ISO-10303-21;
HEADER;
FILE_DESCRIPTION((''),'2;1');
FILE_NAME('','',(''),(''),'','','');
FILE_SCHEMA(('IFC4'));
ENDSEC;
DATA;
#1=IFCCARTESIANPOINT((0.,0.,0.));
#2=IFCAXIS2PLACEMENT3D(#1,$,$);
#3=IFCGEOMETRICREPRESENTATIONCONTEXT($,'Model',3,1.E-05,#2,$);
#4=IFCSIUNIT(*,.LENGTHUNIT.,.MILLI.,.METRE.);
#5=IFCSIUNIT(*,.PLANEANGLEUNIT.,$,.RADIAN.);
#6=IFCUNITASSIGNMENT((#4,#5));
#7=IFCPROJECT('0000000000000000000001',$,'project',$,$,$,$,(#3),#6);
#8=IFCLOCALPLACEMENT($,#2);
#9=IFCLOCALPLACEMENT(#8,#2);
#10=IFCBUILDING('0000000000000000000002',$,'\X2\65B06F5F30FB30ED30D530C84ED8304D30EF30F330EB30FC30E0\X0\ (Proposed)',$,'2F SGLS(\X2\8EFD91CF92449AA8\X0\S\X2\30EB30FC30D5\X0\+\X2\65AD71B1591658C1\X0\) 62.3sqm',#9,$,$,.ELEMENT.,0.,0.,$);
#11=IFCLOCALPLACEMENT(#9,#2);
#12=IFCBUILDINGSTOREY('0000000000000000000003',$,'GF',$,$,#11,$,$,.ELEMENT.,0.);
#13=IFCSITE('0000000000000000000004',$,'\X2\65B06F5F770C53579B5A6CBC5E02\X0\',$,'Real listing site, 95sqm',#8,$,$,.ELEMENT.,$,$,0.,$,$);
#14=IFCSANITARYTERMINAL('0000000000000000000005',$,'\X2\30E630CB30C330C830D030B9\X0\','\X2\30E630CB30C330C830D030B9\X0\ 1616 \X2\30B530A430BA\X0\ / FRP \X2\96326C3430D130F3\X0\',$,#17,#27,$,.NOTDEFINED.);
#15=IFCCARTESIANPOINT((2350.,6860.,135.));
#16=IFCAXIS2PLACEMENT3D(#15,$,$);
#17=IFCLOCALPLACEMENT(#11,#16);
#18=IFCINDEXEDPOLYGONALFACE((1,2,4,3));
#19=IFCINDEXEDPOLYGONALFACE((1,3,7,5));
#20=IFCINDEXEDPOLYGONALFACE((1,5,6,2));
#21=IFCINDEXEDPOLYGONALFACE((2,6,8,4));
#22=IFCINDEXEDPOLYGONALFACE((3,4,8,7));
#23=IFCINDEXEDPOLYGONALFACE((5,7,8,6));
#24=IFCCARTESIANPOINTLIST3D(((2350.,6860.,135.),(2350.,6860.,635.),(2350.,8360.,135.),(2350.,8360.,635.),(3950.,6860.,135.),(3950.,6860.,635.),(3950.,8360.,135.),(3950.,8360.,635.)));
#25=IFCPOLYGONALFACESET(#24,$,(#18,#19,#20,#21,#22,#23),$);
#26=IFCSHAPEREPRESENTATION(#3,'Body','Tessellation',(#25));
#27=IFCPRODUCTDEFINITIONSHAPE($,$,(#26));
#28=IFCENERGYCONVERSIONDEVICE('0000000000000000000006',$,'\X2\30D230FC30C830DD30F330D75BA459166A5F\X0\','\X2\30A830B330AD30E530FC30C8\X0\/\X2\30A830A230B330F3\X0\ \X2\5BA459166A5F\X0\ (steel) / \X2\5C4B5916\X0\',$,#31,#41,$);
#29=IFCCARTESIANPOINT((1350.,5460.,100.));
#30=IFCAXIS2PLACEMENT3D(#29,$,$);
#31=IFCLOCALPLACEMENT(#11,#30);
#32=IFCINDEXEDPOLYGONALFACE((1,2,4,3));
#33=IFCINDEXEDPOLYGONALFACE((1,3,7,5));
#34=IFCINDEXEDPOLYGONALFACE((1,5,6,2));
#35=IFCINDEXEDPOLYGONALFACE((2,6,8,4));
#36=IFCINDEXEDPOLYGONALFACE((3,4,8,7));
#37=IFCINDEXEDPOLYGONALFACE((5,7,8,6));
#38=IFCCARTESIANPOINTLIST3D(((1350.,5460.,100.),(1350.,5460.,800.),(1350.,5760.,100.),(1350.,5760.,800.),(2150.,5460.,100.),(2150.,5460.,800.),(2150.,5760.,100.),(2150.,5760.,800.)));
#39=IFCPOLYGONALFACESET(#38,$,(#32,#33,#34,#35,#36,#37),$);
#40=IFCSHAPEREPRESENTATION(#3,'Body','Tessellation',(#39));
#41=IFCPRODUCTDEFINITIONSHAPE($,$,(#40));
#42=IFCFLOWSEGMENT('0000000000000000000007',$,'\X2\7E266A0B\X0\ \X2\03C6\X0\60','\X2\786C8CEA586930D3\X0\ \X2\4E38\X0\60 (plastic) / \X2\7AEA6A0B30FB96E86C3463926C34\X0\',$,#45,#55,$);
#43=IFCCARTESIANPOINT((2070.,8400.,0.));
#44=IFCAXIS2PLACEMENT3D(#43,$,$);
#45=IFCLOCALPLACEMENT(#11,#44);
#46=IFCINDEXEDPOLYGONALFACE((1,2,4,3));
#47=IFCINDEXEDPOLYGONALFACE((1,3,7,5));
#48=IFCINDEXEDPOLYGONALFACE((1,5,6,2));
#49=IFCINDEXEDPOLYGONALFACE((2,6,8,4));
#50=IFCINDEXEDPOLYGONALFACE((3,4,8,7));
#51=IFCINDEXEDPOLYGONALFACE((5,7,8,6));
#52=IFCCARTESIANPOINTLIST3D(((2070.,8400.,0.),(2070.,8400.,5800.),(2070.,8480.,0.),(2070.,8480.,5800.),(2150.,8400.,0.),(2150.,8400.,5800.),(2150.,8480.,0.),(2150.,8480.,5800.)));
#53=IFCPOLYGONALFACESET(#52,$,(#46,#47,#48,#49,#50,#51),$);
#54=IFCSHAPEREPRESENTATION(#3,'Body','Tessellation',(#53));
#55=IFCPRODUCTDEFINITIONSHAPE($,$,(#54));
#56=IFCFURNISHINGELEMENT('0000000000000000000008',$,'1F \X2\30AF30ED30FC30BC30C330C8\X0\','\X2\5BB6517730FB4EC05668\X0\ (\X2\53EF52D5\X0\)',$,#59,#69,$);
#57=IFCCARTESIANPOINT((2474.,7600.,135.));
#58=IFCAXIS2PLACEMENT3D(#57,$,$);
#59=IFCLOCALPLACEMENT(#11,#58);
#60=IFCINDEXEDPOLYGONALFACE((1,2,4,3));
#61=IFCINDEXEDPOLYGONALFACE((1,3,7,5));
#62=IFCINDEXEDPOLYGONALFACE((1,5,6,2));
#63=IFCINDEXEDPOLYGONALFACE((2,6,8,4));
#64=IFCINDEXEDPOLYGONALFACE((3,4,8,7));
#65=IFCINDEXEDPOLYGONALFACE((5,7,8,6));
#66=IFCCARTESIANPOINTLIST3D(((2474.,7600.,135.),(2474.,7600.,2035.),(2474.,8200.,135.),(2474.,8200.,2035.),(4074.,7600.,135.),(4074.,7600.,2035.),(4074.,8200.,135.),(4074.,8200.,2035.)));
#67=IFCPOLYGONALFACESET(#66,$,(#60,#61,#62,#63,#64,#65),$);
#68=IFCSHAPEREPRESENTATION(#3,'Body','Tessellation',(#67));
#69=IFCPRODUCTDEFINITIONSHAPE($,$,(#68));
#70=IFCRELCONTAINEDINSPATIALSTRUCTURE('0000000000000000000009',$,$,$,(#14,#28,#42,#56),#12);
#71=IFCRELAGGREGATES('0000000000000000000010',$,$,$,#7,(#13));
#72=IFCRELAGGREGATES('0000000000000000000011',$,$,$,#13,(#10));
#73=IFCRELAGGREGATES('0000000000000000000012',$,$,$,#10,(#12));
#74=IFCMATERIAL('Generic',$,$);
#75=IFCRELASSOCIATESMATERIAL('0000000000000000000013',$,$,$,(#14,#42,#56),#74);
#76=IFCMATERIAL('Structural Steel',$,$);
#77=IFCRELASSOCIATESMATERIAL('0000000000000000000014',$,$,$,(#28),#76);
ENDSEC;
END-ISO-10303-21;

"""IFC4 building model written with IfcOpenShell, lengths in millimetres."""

from ifc_helpers import new_model, si_unit, frame, frame_2d, origin, place, context, project, spatial, rectangle, extrude, material, element, save


model = new_model("IFC4")

# Units and contexts
model_context = context("Model", 3, precision=1e-05, world=origin())
ifc_project = project(units=[si_unit("LENGTHUNIT", "METRE", prefix="MILLI"), si_unit("PLANEANGLEUNIT", "RADIAN")], contexts=[model_context])

# Site, building, storey
site_placement = place(None, origin())
site = spatial("IfcSite", under=ifc_project, at=site_placement, Name="新潟県南魚沼市", ObjectType="Real listing site, 95sqm", CompositionType="ELEMENT", RefElevation=0.0)
building_placement = place(site_placement, origin())
building = spatial("IfcBuilding", under=site, at=building_placement, Name="新潟・ロフト付きワンルーム (Proposed)", ObjectType="2F SGLS(軽量鉄骨Sルーフ+断熱外壁) 62.3sqm", CompositionType="ELEMENT", ElevationOfRefHeight=0.0, ElevationOfTerrain=0.0)
storey_placement = place(building_placement, origin())
storey = spatial("IfcBuildingStorey", under=building, at=storey_placement, Name="GF", CompositionType="ELEMENT", Elevation=0.0)

# Shared definitions
ifc_material_1 = material(Name="Generic")

# Sanitary terminal
sanitary_terminal_placement = place(storey_placement, frame((2350.0, 6860.0, 135.0)))
element("IfcSanitaryTerminal", 1, at=sanitary_terminal_placement, inside=storey, material=ifc_material_1, Name="ユニットバス", Description="ユニットバス 1616 サイズ / FRP 防水パン", PredefinedType="NOTDEFINED", context=model_context, shape_type="SweptSolid", body=[
    extrude(rectangle(XDim=1600.0, YDim=1500.0, at=frame_2d((800.0, 750.0))), frame((2350.0, 6860.0, 135.0)), (0.0, 0.0, 1.0), 500.0),
])

# Energy conversion device
ifc_material_2 = material(Name="Structural Steel")
energy_conversion_device_placement = place(storey_placement, frame((1350.0, 5460.0, 100.0)))
element("IfcEnergyConversionDevice", 2, at=energy_conversion_device_placement, inside=storey, material=ifc_material_2, Name="ヒートポンプ室外機", Description="エコキュート/エアコン 室外機 (steel) / 屋外", context=model_context, shape_type="SweptSolid", body=[
    extrude(rectangle(XDim=800.0, YDim=300.0, at=frame_2d((400.0, 150.0))), frame((1350.0, 5460.0, 100.0)), (0.0, 0.0, 1.0), 700.0),
])

# Flow segment
flow_segment_placement = place(storey_placement, frame((2070.0, 8400.0, 0.0)))
element("IfcFlowSegment", 3, at=flow_segment_placement, inside=storey, material=ifc_material_1, Name="縦樋 φ60", Description="硬質塩ビ 丸60 (plastic) / 竪樋・雨水排水", context=model_context, shape_type="SweptSolid", body=[
    extrude(rectangle(XDim=80.0, YDim=80.0, at=frame_2d((40.0, 40.0))), frame((2070.0, 8400.0, 0.0)), (0.0, 0.0, 1.0), 5800.0),
])

# Furnishing element
furnishing_placement = place(storey_placement, frame((2474.0, 7600.0, 135.0)))
element("IfcFurnishingElement", 4, at=furnishing_placement, inside=storey, material=ifc_material_1, Name="1F クローゼット", Description="家具・什器 (可動)", context=model_context, shape_type="SweptSolid", body=[
    extrude(rectangle(XDim=1600.0, YDim=600.0, at=frame_2d((800.0, 300.0))), frame((2474.0, 7600.0, 135.0)), (0.0, 0.0, 1.0), 1900.0),
])

save(model, "model.ifc")
